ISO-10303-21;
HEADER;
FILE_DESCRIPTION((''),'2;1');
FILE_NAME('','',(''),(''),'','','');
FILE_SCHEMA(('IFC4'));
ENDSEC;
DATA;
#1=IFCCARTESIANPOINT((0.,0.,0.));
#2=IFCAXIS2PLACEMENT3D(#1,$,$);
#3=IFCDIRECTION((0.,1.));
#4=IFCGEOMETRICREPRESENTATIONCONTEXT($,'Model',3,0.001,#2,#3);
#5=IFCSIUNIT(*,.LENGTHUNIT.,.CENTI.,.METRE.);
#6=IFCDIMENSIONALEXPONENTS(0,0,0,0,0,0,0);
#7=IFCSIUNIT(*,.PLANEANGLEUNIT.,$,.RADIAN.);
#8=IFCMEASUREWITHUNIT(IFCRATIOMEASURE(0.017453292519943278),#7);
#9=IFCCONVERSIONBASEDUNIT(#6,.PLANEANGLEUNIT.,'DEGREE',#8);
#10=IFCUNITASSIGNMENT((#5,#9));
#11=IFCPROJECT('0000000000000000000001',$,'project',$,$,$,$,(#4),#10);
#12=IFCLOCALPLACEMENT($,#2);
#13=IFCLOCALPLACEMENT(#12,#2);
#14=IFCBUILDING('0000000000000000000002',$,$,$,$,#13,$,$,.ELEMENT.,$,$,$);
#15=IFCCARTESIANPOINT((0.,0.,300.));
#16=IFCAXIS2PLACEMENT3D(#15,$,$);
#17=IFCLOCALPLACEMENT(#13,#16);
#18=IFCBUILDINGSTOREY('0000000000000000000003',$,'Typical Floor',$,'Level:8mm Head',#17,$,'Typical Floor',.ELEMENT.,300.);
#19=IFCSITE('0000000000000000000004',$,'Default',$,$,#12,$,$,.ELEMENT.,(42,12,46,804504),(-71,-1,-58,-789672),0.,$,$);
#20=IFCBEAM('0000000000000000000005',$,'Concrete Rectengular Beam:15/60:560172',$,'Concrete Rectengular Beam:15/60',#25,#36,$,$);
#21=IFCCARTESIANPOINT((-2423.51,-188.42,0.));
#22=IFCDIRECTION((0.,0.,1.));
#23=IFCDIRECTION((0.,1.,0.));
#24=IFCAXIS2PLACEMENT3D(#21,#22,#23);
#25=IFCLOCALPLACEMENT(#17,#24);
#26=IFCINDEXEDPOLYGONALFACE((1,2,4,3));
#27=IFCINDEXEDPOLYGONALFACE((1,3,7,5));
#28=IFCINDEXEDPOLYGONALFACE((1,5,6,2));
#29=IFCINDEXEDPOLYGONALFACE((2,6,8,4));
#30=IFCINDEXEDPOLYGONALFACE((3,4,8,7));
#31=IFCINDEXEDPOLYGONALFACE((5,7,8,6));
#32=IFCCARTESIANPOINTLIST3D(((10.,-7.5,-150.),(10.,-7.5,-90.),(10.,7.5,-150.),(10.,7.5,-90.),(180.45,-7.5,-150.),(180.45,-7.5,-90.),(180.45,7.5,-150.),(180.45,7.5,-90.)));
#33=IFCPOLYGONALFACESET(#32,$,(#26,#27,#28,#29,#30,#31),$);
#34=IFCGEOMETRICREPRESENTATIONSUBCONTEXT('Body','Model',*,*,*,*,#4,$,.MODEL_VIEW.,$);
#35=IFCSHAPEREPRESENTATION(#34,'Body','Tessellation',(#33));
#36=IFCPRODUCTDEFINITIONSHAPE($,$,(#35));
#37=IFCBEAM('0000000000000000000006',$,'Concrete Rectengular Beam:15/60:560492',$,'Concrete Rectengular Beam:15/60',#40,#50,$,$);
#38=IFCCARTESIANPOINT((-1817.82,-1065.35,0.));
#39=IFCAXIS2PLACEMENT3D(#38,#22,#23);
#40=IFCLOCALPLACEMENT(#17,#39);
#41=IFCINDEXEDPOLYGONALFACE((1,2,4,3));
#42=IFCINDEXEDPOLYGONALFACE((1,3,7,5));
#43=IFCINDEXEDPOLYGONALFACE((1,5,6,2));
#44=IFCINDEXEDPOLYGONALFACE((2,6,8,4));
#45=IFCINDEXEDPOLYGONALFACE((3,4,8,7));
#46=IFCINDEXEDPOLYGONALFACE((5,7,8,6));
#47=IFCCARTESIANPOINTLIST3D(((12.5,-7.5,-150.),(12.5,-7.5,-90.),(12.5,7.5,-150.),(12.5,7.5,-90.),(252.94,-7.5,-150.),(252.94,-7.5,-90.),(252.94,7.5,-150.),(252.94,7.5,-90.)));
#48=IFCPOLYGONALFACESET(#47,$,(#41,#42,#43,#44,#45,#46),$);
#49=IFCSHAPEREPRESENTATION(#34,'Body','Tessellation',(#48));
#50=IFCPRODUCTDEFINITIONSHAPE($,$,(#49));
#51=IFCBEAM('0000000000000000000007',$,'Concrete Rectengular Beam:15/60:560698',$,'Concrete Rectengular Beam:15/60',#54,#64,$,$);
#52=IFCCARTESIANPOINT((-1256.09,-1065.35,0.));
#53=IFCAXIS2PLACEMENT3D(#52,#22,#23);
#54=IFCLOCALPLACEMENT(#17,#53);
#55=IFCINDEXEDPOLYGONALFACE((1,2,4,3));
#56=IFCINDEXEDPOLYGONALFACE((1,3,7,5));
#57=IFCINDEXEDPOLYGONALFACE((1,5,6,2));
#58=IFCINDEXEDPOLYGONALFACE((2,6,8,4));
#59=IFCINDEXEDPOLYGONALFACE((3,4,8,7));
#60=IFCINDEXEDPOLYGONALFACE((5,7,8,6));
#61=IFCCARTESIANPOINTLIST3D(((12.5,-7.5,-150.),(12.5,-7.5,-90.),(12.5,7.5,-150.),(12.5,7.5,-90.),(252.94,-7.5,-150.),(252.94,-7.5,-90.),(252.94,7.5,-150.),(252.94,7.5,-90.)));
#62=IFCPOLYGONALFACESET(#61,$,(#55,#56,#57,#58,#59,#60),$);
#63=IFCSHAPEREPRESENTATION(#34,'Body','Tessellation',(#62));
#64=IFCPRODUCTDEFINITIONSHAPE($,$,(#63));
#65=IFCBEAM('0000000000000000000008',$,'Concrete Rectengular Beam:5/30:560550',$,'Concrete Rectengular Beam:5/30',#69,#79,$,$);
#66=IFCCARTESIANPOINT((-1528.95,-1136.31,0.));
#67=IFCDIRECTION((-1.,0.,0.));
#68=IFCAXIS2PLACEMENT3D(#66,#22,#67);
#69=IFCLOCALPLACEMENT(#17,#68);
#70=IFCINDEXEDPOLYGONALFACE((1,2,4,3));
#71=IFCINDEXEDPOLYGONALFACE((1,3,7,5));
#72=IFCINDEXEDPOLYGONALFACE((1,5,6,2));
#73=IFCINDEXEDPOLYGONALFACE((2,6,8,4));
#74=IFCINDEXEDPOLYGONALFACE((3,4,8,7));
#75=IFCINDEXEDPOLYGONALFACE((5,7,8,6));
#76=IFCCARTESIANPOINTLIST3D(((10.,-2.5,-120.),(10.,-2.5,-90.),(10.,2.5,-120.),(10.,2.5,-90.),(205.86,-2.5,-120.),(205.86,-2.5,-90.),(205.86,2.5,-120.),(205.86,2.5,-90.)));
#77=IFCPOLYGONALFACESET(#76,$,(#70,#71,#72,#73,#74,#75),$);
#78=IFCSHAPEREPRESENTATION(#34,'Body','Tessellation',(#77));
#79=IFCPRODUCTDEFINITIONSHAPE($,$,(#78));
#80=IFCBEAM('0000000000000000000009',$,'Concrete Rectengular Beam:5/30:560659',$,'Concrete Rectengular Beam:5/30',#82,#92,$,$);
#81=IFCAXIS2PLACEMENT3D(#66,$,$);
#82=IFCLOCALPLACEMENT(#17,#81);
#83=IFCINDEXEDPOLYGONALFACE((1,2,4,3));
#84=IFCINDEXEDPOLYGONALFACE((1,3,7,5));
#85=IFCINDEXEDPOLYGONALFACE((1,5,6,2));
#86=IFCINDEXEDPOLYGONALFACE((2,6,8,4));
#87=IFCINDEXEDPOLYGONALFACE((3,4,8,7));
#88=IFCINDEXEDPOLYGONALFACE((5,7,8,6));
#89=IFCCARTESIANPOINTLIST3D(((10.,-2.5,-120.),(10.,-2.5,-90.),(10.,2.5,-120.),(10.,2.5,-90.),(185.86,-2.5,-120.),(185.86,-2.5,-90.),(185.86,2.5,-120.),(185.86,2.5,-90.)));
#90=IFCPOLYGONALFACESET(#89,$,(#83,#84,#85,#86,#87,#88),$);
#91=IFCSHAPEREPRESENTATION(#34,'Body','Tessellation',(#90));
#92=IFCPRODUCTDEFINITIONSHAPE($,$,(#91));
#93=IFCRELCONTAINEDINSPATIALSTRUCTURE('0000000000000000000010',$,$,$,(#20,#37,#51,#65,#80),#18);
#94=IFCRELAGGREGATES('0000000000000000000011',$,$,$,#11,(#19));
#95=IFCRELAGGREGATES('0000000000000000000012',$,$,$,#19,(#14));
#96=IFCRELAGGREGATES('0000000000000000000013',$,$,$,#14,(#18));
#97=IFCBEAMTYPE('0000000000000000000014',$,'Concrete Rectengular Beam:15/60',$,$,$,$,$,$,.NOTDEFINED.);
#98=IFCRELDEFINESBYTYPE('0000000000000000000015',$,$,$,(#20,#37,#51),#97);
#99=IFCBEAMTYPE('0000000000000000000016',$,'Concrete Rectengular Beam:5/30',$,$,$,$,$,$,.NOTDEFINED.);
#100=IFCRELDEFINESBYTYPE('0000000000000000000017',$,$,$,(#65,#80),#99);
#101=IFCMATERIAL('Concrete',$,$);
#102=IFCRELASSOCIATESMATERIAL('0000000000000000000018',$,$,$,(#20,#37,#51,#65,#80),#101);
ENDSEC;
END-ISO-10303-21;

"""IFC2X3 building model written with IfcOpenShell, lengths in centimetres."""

from ifc_helpers import new_model, entity, si_unit, converted_unit, direction, frame, frame_2d, origin, place, context, subcontext, project, spatial, rectangle, extrude, material, type_object, element, save


model = new_model("IFC2X3")

# Units and contexts
model_context = context("Model", 3, precision=0.001, world=origin(), true_north=direction((0.0, 1.0)))
body_context = subcontext(model_context, "Body", "Model", "MODEL_VIEW")
ifc_project = project(units=[si_unit("LENGTHUNIT", "METRE", prefix="CENTI"), converted_unit("PLANEANGLEUNIT", "DEGREE", entity("IfcRatioMeasure", 0.017453292519943278), si_unit("PLANEANGLEUNIT", "RADIAN"), dimensions=[0, 0, 0, 0, 0, 0, 0])], contexts=[model_context])

# Site, building, storey
site_placement = place(None, origin())
site = spatial("IfcSite", under=ifc_project, at=site_placement, Name="Default", CompositionType="ELEMENT", RefLatitude=(42, 12, 46, 804504), RefLongitude=(-71, -1, -58, -789672), RefElevation=0.0)
building_placement = place(site_placement, origin())
building = spatial("IfcBuilding", under=site, at=building_placement, CompositionType="ELEMENT")
storey_placement = place(building_placement, frame((0.0, 0.0, 300.0)))
storey = spatial("IfcBuildingStorey", under=building, at=storey_placement, Name="Typical Floor", ObjectType="Level:8mm Head", LongName="Typical Floor", CompositionType="ELEMENT", Elevation=300.0)

# Beams
ifc_material = material(Name="Concrete")
beam_type_1 = type_object("IfcBeamType", Name="Concrete Rectengular Beam:15/60", PredefinedType="NOTDEFINED")
beam_1_placement = place(storey_placement, frame((-2423.51, -188.42, 0.0), z_axis=(0.0, 0.0, 1.0), x_axis=(0.0, 1.0, 0.0)))
element("IfcBeam", 1, at=beam_1_placement, inside=storey, type_object=beam_type_1, material=ifc_material, Name="Concrete Rectengular Beam:15/60:560172", ObjectType="Concrete Rectengular Beam:15/60", context=body_context, shape_type="SweptSolid", body=[
    extrude(rectangle(XDim=60.0, YDim=15.0, at=frame_2d((0.0, 0.0), x_axis=(1.0, 0.0))), frame((10.0, 0.0, -120.0), z_axis=(1.0, 0.0, 0.0), x_axis=(0.0, 0.0, -1.0)), (0.0, 0.0, 1.0), 170.45),
])
beam_2_placement = place(storey_placement, frame((-1817.82, -1065.35, 0.0), z_axis=(0.0, 0.0, 1.0), x_axis=(0.0, 1.0, 0.0)))
element("IfcBeam", 2, at=beam_2_placement, inside=storey, type_object=beam_type_1, material=ifc_material, Name="Concrete Rectengular Beam:15/60:560492", ObjectType="Concrete Rectengular Beam:15/60", context=body_context, shape_type="SweptSolid", body=[
    extrude(rectangle(XDim=60.0, YDim=15.0, at=frame_2d((0.0, 0.0), x_axis=(1.0, 0.0))), frame((12.5, 0.0, -120.0), z_axis=(1.0, 0.0, 0.0), x_axis=(0.0, 0.0, -1.0)), (0.0, 0.0, 1.0), 240.44),
])
beam_3_placement = place(storey_placement, frame((-1256.09, -1065.35, 0.0), z_axis=(0.0, 0.0, 1.0), x_axis=(0.0, 1.0, 0.0)))
element("IfcBeam", 3, at=beam_3_placement, inside=storey, type_object=beam_type_1, material=ifc_material, Name="Concrete Rectengular Beam:15/60:560698", ObjectType="Concrete Rectengular Beam:15/60", context=body_context, shape_type="SweptSolid", body=[
    extrude(rectangle(XDim=60.0, YDim=15.0, at=frame_2d((0.0, 0.0), x_axis=(1.0, 0.0))), frame((12.5, 0.0, -120.0), z_axis=(1.0, 0.0, 0.0), x_axis=(0.0, 0.0, -1.0)), (0.0, 0.0, 1.0), 240.44),
])
beam_type_2 = type_object("IfcBeamType", Name="Concrete Rectengular Beam:5/30", PredefinedType="NOTDEFINED")
beam_4_placement = place(storey_placement, frame((-1528.95, -1136.31, 0.0), z_axis=(0.0, 0.0, 1.0), x_axis=(-1.0, 0.0, 0.0)))
element("IfcBeam", 4, at=beam_4_placement, inside=storey, type_object=beam_type_2, material=ifc_material, Name="Concrete Rectengular Beam:5/30:560550", ObjectType="Concrete Rectengular Beam:5/30", context=body_context, shape_type="SweptSolid", body=[
    extrude(rectangle(XDim=30.0, YDim=5.0, at=frame_2d((0.0, 0.0), x_axis=(1.0, 0.0))), frame((10.0, 0.0, -105.0), z_axis=(1.0, 0.0, 0.0), x_axis=(0.0, 0.0, -1.0)), (0.0, 0.0, 1.0), 195.86),
])
beam_5_placement = place(storey_placement, frame((-1528.95, -1136.31, 0.0)))
element("IfcBeam", 5, at=beam_5_placement, inside=storey, type_object=beam_type_2, material=ifc_material, Name="Concrete Rectengular Beam:5/30:560659", ObjectType="Concrete Rectengular Beam:5/30", context=body_context, shape_type="SweptSolid", body=[
    extrude(rectangle(XDim=30.0, YDim=5.0, at=frame_2d((0.0, 0.0), x_axis=(1.0, 0.0))), frame((10.0, 0.0, -105.0), z_axis=(1.0, 0.0, 0.0), x_axis=(0.0, 0.0, -1.0)), (0.0, 0.0, 1.0), 175.86),
])

save(model, "model.ifc")
